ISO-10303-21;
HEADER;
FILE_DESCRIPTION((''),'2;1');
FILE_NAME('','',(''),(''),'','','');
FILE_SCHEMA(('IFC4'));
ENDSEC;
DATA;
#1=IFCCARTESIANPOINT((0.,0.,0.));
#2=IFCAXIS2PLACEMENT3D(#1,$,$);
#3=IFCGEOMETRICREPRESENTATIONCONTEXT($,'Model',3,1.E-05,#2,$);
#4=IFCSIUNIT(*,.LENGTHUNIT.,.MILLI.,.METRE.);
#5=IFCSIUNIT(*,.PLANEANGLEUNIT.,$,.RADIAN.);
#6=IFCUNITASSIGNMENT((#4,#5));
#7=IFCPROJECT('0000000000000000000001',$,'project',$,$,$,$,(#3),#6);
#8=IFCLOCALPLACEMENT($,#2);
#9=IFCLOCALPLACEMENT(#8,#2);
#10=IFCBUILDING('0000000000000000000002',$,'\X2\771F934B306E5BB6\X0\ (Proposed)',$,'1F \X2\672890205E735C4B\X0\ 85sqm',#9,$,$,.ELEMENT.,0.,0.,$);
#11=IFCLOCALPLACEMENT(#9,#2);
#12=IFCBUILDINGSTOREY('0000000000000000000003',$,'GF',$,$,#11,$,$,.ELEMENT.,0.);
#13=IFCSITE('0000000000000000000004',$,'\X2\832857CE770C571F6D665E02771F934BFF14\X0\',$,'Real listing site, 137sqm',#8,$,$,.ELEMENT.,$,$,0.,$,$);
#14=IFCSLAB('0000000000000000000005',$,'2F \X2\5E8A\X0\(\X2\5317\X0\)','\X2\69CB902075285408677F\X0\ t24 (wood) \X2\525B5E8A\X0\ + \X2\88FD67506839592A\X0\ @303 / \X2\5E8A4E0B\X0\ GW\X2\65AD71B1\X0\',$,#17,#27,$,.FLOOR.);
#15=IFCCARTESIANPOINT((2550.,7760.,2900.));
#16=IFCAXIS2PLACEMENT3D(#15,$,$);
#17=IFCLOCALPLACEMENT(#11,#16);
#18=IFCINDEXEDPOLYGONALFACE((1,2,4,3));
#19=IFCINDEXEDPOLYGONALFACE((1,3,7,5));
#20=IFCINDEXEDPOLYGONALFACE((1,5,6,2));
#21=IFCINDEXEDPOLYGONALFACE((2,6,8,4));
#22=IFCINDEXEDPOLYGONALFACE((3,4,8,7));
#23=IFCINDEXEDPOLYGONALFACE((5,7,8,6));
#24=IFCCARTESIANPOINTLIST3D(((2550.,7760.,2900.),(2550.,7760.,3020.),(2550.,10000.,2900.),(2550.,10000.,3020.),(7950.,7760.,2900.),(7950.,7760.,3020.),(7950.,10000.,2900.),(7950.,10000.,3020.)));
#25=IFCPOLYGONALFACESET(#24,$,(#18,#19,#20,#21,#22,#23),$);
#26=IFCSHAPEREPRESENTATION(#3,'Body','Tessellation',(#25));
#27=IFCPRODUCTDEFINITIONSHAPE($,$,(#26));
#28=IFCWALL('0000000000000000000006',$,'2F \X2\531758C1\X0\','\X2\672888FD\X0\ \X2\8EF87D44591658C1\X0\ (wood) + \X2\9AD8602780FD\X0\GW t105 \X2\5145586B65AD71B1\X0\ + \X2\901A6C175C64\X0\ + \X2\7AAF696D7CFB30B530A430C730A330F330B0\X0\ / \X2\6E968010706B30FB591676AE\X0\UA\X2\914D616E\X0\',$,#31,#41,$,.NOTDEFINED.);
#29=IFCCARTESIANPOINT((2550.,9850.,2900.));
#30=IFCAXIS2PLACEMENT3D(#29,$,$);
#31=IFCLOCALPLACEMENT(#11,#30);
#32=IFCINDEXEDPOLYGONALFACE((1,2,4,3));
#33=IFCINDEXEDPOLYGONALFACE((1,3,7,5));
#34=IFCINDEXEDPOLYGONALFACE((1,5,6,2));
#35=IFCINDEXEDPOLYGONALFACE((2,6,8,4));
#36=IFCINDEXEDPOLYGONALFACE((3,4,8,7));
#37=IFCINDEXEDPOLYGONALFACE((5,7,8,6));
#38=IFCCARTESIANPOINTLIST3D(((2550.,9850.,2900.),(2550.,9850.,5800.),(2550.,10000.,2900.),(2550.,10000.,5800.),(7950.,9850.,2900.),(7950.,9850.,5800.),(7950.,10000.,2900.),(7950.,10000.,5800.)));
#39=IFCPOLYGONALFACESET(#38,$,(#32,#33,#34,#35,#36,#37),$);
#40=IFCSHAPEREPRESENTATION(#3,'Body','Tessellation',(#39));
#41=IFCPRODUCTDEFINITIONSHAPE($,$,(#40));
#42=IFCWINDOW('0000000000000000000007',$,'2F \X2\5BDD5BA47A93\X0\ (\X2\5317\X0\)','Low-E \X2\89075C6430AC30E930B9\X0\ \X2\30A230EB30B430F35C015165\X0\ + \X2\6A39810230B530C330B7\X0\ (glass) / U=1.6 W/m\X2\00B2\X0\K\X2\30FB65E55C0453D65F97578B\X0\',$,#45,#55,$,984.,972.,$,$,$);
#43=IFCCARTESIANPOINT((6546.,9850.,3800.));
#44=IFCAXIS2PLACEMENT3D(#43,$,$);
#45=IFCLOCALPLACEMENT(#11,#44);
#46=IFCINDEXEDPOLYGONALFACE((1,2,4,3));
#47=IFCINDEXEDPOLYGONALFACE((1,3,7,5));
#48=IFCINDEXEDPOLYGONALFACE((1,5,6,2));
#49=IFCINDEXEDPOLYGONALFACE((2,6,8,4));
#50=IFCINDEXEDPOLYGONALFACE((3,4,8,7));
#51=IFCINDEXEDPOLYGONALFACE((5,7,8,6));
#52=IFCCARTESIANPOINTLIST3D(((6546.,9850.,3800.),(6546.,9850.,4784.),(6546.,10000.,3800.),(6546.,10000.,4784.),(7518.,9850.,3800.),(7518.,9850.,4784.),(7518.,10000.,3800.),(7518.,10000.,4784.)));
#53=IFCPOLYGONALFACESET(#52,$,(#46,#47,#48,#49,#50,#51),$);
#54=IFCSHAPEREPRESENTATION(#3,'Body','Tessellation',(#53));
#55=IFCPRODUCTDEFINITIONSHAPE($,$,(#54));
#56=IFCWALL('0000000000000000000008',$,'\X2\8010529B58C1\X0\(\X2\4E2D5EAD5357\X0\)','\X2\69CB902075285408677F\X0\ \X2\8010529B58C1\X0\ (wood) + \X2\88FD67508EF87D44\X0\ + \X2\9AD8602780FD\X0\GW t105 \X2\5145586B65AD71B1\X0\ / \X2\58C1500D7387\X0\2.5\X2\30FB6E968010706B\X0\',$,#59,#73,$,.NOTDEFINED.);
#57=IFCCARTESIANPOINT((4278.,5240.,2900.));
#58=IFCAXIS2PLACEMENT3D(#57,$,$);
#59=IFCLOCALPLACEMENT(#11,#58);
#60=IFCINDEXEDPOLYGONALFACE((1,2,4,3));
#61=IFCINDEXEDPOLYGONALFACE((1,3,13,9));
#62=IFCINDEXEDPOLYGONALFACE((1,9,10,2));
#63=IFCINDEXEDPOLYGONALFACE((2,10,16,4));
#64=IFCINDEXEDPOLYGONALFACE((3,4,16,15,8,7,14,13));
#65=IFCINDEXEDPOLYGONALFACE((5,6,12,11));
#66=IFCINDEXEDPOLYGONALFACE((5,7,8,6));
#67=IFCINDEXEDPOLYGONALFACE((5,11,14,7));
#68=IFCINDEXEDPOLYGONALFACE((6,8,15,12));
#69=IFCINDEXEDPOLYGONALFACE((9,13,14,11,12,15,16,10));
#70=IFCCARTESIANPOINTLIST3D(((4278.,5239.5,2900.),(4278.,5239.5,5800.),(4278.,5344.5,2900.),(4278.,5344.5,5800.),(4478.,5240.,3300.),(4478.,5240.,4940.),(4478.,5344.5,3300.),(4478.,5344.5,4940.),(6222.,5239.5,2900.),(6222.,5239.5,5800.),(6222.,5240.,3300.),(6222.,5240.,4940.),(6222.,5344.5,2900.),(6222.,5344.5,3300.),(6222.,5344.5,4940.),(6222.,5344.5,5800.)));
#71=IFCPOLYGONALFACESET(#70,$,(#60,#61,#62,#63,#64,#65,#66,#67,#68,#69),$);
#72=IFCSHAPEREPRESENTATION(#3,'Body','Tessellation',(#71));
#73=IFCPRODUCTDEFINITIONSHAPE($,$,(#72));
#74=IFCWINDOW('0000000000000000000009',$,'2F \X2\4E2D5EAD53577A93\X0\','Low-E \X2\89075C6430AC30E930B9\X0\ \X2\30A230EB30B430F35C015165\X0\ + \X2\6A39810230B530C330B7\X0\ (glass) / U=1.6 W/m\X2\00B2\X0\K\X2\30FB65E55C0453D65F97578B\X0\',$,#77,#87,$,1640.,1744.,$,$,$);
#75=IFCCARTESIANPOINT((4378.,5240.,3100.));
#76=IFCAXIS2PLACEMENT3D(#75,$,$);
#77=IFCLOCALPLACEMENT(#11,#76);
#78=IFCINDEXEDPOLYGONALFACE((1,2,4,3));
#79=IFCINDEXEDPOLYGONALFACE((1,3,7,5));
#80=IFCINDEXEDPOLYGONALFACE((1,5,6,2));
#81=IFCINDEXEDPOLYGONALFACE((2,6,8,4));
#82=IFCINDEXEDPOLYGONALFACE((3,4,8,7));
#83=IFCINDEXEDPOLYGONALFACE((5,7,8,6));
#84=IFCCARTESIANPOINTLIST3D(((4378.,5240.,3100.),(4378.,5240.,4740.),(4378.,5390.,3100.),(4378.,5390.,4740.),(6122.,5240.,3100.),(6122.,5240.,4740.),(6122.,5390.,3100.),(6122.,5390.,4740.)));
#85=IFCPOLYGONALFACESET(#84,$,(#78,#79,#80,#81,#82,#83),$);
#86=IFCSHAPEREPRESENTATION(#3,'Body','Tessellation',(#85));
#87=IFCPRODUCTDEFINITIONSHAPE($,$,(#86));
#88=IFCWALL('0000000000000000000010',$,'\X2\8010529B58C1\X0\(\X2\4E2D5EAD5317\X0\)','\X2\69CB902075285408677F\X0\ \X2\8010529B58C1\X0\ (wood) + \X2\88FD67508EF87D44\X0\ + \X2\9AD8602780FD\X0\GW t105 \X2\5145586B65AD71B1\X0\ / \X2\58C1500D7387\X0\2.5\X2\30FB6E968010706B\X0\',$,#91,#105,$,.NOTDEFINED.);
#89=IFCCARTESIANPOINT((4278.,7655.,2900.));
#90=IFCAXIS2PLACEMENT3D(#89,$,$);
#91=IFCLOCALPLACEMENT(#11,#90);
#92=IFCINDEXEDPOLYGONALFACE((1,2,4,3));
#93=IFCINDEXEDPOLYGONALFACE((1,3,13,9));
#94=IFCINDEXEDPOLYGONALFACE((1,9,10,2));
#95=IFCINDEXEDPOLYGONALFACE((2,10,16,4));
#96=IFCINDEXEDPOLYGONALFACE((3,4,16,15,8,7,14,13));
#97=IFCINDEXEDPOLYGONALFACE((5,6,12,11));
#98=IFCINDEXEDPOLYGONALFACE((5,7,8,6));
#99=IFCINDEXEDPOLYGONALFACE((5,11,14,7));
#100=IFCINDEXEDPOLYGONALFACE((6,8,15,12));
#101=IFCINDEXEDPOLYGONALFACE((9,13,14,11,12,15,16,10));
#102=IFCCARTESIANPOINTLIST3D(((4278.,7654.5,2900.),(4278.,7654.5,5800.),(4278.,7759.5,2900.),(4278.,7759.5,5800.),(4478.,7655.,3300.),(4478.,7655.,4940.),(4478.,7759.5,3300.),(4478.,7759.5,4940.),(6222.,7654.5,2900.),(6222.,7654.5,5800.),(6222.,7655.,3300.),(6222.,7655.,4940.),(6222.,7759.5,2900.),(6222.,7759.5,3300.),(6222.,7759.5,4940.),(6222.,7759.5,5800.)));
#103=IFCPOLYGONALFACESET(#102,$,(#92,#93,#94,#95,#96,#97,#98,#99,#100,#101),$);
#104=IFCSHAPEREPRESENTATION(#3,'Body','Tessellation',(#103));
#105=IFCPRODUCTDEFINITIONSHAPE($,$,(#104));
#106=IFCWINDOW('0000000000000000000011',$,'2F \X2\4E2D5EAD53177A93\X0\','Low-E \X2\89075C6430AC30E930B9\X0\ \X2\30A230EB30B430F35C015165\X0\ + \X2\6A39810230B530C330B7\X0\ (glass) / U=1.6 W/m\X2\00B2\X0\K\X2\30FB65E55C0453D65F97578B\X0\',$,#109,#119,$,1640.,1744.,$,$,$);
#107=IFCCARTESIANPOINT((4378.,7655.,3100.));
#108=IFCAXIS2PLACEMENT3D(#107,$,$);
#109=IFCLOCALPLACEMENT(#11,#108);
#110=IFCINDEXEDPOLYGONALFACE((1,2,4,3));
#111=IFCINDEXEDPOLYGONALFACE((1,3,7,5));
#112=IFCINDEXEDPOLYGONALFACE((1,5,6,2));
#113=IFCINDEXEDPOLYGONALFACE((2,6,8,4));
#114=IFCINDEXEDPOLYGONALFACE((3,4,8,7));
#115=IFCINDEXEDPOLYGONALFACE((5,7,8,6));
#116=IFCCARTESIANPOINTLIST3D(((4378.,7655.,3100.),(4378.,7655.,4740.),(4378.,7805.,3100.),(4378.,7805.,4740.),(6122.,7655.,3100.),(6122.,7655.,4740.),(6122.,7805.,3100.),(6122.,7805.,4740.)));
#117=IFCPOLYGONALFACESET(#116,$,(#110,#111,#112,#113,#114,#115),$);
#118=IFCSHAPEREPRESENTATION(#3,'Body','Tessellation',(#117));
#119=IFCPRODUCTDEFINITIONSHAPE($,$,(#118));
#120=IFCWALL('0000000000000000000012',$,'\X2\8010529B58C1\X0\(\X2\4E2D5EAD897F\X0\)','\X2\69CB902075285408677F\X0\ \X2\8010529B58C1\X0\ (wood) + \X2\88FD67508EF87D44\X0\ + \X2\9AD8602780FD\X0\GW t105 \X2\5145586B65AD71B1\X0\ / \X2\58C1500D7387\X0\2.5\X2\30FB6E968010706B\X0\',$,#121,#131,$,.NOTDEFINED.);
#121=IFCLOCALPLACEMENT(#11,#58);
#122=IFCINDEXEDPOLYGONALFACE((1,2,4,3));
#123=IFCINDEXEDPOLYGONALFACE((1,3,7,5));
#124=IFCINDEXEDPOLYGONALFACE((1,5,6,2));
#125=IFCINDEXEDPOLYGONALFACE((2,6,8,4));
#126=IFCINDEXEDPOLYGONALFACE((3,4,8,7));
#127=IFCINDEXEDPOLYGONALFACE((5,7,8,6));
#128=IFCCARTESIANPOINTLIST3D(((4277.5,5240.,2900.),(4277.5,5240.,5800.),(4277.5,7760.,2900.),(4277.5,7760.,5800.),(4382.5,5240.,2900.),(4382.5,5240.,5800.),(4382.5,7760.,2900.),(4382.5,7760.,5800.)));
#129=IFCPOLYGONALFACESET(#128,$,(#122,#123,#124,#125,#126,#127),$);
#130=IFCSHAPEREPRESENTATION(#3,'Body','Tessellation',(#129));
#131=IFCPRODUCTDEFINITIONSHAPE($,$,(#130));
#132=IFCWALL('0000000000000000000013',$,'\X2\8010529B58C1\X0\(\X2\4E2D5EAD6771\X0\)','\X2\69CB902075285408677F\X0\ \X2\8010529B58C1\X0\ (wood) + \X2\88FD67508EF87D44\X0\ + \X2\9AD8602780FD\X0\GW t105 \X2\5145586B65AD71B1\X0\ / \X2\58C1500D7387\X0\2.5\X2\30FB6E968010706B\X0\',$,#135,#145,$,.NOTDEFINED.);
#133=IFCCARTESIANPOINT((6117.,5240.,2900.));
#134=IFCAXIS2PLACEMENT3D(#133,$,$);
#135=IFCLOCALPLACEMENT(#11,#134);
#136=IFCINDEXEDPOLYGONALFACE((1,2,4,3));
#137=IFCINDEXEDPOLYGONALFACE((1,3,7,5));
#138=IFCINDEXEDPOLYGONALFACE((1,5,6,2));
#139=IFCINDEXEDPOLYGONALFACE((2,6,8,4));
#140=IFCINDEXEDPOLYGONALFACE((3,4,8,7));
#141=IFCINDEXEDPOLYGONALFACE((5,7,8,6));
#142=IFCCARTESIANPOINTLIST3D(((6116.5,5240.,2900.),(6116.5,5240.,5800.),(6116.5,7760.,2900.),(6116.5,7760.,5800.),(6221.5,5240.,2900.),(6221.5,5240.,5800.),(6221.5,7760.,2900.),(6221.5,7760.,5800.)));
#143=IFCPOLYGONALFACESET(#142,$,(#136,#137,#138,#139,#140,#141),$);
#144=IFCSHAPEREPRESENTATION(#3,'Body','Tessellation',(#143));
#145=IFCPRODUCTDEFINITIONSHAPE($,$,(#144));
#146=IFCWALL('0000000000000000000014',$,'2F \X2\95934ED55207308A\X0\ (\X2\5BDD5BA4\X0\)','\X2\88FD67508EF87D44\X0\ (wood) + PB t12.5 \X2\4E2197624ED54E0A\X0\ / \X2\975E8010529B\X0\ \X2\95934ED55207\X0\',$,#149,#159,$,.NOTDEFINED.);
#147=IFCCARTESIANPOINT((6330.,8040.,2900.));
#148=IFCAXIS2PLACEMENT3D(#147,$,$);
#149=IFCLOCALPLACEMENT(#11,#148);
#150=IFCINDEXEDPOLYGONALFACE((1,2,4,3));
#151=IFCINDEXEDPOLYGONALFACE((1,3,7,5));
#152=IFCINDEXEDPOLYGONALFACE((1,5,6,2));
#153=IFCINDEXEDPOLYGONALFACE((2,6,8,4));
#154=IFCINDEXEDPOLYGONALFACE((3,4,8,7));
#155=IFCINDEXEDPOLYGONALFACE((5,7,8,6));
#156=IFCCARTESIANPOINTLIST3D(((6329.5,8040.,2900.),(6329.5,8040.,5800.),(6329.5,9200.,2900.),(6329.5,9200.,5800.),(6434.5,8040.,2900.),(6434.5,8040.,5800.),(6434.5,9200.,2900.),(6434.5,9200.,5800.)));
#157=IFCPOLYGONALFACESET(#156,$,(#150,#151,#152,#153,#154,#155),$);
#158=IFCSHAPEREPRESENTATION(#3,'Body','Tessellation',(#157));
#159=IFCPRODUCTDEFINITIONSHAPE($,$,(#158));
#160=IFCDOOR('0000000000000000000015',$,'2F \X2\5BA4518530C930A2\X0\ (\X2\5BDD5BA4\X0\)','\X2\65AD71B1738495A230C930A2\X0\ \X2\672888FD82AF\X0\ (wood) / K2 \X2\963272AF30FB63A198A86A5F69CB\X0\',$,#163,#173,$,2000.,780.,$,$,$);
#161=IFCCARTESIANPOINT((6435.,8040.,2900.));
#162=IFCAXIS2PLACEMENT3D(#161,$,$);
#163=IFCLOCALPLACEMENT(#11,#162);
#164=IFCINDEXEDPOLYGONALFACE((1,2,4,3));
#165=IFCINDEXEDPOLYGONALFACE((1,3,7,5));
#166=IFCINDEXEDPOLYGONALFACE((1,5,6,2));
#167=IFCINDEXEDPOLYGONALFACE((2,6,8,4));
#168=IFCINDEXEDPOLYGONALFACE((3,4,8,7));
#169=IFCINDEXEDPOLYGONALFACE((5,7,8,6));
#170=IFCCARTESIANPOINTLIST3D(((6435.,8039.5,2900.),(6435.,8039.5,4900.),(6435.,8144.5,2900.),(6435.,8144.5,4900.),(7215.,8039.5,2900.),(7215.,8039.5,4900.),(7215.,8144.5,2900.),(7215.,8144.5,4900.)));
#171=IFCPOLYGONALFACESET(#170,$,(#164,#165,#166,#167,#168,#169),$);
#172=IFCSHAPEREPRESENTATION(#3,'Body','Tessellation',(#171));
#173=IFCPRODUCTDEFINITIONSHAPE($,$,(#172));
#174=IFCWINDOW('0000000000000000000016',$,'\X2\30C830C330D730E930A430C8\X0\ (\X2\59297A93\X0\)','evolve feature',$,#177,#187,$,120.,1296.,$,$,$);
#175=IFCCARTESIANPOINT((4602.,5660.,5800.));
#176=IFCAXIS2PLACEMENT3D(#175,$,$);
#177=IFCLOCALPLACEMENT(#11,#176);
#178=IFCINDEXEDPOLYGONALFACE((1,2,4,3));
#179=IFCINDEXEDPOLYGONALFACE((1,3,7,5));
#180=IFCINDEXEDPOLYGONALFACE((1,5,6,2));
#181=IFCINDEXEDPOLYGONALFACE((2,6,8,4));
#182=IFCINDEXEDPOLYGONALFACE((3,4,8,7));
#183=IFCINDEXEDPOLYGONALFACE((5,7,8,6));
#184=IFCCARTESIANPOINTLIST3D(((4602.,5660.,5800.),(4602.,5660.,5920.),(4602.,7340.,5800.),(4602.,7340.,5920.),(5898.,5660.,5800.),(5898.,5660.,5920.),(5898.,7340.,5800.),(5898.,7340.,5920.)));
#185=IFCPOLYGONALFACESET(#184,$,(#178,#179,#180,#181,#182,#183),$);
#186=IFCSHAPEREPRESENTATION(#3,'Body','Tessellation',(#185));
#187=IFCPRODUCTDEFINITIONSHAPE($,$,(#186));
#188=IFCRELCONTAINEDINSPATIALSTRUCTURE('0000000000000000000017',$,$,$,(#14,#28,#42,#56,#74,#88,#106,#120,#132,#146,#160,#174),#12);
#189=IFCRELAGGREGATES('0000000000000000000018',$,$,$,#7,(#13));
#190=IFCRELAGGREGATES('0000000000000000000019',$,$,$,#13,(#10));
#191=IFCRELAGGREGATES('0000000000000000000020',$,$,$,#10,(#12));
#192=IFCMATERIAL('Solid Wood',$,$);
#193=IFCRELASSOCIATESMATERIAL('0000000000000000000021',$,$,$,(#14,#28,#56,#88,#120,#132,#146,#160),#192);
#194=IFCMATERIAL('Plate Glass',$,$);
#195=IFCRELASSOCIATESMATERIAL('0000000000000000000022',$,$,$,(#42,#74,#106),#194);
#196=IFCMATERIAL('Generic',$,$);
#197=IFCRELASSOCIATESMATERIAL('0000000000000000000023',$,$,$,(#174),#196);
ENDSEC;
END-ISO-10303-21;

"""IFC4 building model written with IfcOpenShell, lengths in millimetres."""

from ifc_helpers import new_model, si_unit, frame, frame_2d, origin, place, context, project, spatial, rectangle, extrude, material, element, fill, save


model = new_model("IFC4")

# Units and contexts
model_context = context("Model", 3, precision=1e-05, world=origin())
ifc_project = project(units=[si_unit("LENGTHUNIT", "METRE", prefix="MILLI"), si_unit("PLANEANGLEUNIT", "RADIAN")], contexts=[model_context])

# Site, building, storey
site_placement = place(None, origin())
site = spatial("IfcSite", under=ifc_project, at=site_placement, Name="茨城県土浦市真鍋４", ObjectType="Real listing site, 137sqm", CompositionType="ELEMENT", RefElevation=0.0)
building_placement = place(site_placement, origin())
building = spatial("IfcBuilding", under=site, at=building_placement, Name="真鍋の家 (Proposed)", ObjectType="1F 木造平屋 85sqm", CompositionType="ELEMENT", ElevationOfRefHeight=0.0, ElevationOfTerrain=0.0)
storey_placement = place(building_placement, origin())
storey = spatial("IfcBuildingStorey", under=building, at=storey_placement, Name="GF", CompositionType="ELEMENT", Elevation=0.0)

# Slab
ifc_material_1 = material(Name="Solid Wood")
slab_placement = place(storey_placement, frame((2550.0, 7760.0, 2900.0)))
element("IfcSlab", 1, at=slab_placement, inside=storey, material=ifc_material_1, Name="2F 床(北)", Description="構造用合板 t24 (wood) 剛床 + 製材根太 @303 / 床下 GW断熱", PredefinedType="FLOOR", context=model_context, shape_type="SweptSolid", body=[
    extrude(rectangle(XDim=5400.0, YDim=2240.0, at=frame_2d((2700.0, 1120.0))), frame((2550.0, 7760.0, 2900.0)), (0.0, 0.0, 1.0), 120.0),
])

# Walls, openings, windows
wall_1_placement = place(storey_placement, frame((2550.0, 9850.0, 2900.0)))
wall_1 = element("IfcWall", 2, at=wall_1_placement, inside=storey, material=ifc_material_1, Name="2F 北壁", Description="木製 軸組外壁 (wood) + 高性能GW t105 充填断熱 + 通気層 + 窯業系サイディング / 準耐火・外皮UA配慮", PredefinedType="NOTDEFINED", context=model_context, shape_type="SweptSolid", body=[
    extrude(rectangle(XDim=5400.0, YDim=150.0, at=frame_2d((2700.0, 75.0))), frame((2550.0, 9850.0, 2900.0)), (0.0, 0.0, 1.0), 2900.0),
])
opening_1_placement = place(storey_placement, frame((6546.0, 9850.0, 3800.0)))
opening_1 = element("IfcOpeningElement", 3, at=opening_1_placement, cuts=wall_1, PredefinedType="NOTDEFINED", context=model_context, shape_type="SweptSolid", body=[
    extrude(rectangle(XDim=972.0, YDim=150.0, at=frame_2d((486.0, 75.0))), frame((6546.0, 9850.0, 3800.0)), (0.0, 0.0, 1.0), 984.0),
])
ifc_material_2 = material(Name="Plate Glass")
window_1_placement = place(storey_placement, frame((6546.0, 9850.0, 3800.0)))
window_1 = element("IfcWindow", 4, at=window_1_placement, inside=storey, material=ifc_material_2, Name="2F 寝室窓 (北)", Description="Low-E 複層ガラス アルゴン封入 + 樹脂サッシ (glass) / U=1.6 W/m²K・日射取得型", OverallHeight=984.0, OverallWidth=972.0, context=model_context, shape_type="SweptSolid", body=[
    extrude(rectangle(XDim=972.0, YDim=150.0, at=frame_2d((486.0, 75.0))), frame((6546.0, 9850.0, 3800.0)), (0.0, 0.0, 1.0), 984.0),
])
fill(opening_1, window_1)
wall_2_placement = place(storey_placement, frame((4278.0, 5240.0, 2900.0)))
wall_2 = element("IfcWall", 5, at=wall_2_placement, inside=storey, material=ifc_material_1, Name="耐力壁(中庭南)", Description="構造用合板 耐力壁 (wood) + 製材軸組 + 高性能GW t105 充填断熱 / 壁倍率2.5・準耐火", PredefinedType="NOTDEFINED", context=model_context, shape_type="SweptSolid", body=[
    extrude(rectangle(XDim=1944.0, YDim=105.0, at=frame_2d((972.0, 52.0))), frame((4278.0, 5240.0, 2900.0)), (0.0, 0.0, 1.0), 2900.0),
])
opening_2_placement = place(storey_placement, frame((4378.0, 5240.0, 3100.0)))
opening_2 = element("IfcOpeningElement", 6, at=opening_2_placement, cuts=wall_2, PredefinedType="NOTDEFINED", context=model_context, shape_type="SweptSolid", body=[
    extrude(rectangle(XDim=1744.0, YDim=150.0, at=frame_2d((872.0, 75.0))), frame((4378.0, 5240.0, 3100.0)), (0.0, 0.0, 1.0), 1640.0),
])
window_2_placement = place(storey_placement, frame((4378.0, 5240.0, 3100.0)))
window_2 = element("IfcWindow", 7, at=window_2_placement, inside=storey, material=ifc_material_2, Name="2F 中庭南窓", Description="Low-E 複層ガラス アルゴン封入 + 樹脂サッシ (glass) / U=1.6 W/m²K・日射取得型", OverallHeight=1640.0, OverallWidth=1744.0, context=model_context, shape_type="SweptSolid", body=[
    extrude(rectangle(XDim=1744.0, YDim=150.0, at=frame_2d((872.0, 75.0))), frame((4378.0, 5240.0, 3100.0)), (0.0, 0.0, 1.0), 1640.0),
])
fill(opening_2, window_2)
wall_3_placement = place(storey_placement, frame((4278.0, 7655.0, 2900.0)))
wall_3 = element("IfcWall", 8, at=wall_3_placement, inside=storey, material=ifc_material_1, Name="耐力壁(中庭北)", Description="構造用合板 耐力壁 (wood) + 製材軸組 + 高性能GW t105 充填断熱 / 壁倍率2.5・準耐火", PredefinedType="NOTDEFINED", context=model_context, shape_type="SweptSolid", body=[
    extrude(rectangle(XDim=1944.0, YDim=105.0, at=frame_2d((972.0, 52.0))), frame((4278.0, 7655.0, 2900.0)), (0.0, 0.0, 1.0), 2900.0),
])
opening_3_placement = place(storey_placement, frame((4378.0, 7655.0, 3100.0)))
opening_3 = element("IfcOpeningElement", 9, at=opening_3_placement, cuts=wall_3, PredefinedType="NOTDEFINED", context=model_context, shape_type="SweptSolid", body=[
    extrude(rectangle(XDim=1744.0, YDim=150.0, at=frame_2d((872.0, 75.0))), frame((4378.0, 7655.0, 3100.0)), (0.0, 0.0, 1.0), 1640.0),
])
window_3_placement = place(storey_placement, frame((4378.0, 7655.0, 3100.0)))
window_3 = element("IfcWindow", 10, at=window_3_placement, inside=storey, material=ifc_material_2, Name="2F 中庭北窓", Description="Low-E 複層ガラス アルゴン封入 + 樹脂サッシ (glass) / U=1.6 W/m²K・日射取得型", OverallHeight=1640.0, OverallWidth=1744.0, context=model_context, shape_type="SweptSolid", body=[
    extrude(rectangle(XDim=1744.0, YDim=150.0, at=frame_2d((872.0, 75.0))), frame((4378.0, 7655.0, 3100.0)), (0.0, 0.0, 1.0), 1640.0),
])
fill(opening_3, window_3)

# Walls
wall_4_placement = place(storey_placement, frame((4278.0, 5240.0, 2900.0)))
element("IfcWall", 11, at=wall_4_placement, inside=storey, material=ifc_material_1, Name="耐力壁(中庭西)", Description="構造用合板 耐力壁 (wood) + 製材軸組 + 高性能GW t105 充填断熱 / 壁倍率2.5・準耐火", PredefinedType="NOTDEFINED", context=model_context, shape_type="SweptSolid", body=[
    extrude(rectangle(XDim=105.0, YDim=2520.0, at=frame_2d((52.0, 1260.0))), frame((4278.0, 5240.0, 2900.0)), (0.0, 0.0, 1.0), 2900.0),
])
wall_5_placement = place(storey_placement, frame((6117.0, 5240.0, 2900.0)))
element("IfcWall", 12, at=wall_5_placement, inside=storey, material=ifc_material_1, Name="耐力壁(中庭東)", Description="構造用合板 耐力壁 (wood) + 製材軸組 + 高性能GW t105 充填断熱 / 壁倍率2.5・準耐火", PredefinedType="NOTDEFINED", context=model_context, shape_type="SweptSolid", body=[
    extrude(rectangle(XDim=105.0, YDim=2520.0, at=frame_2d((52.0, 1260.0))), frame((6117.0, 5240.0, 2900.0)), (0.0, 0.0, 1.0), 2900.0),
])
wall_6_placement = place(storey_placement, frame((6330.0, 8040.0, 2900.0)))
element("IfcWall", 13, at=wall_6_placement, inside=storey, material=ifc_material_1, Name="2F 間仕切り (寝室)", Description="製材軸組 (wood) + PB t12.5 両面仕上 / 非耐力 間仕切", PredefinedType="NOTDEFINED", context=model_context, shape_type="SweptSolid", body=[
    extrude(rectangle(XDim=105.0, YDim=1160.0, at=frame_2d((52.0, 580.0))), frame((6330.0, 8040.0, 2900.0)), (0.0, 0.0, 1.0), 2900.0),
])

# Door
door_placement = place(storey_placement, frame((6435.0, 8040.0, 2900.0)))
element("IfcDoor", 14, at=door_placement, inside=storey, material=ifc_material_1, Name="2F 室内ドア (寝室)", Description="断熱玄関ドア 木製芯 (wood) / K2 防犯・採風機構", OverallHeight=2000.0, OverallWidth=780.0, context=model_context, shape_type="SweptSolid", body=[
    extrude(rectangle(XDim=780.0, YDim=105.0, at=frame_2d((390.0, 52.0))), frame((6435.0, 8040.0, 2900.0)), (0.0, 0.0, 1.0), 2000.0),
])

# Window
ifc_material_3 = material(Name="Generic")
window_4_placement = place(storey_placement, frame((4602.0, 5660.0, 5800.0)))
element("IfcWindow", 15, at=window_4_placement, inside=storey, material=ifc_material_3, Name="トップライト (天窓)", Description="evolve feature", OverallHeight=120.0, OverallWidth=1296.0, context=model_context, shape_type="SweptSolid", body=[
    extrude(rectangle(XDim=1296.0, YDim=1680.0, at=frame_2d((648.0, 840.0))), frame((4602.0, 5660.0, 5800.0)), (0.0, 0.0, 1.0), 120.0),
])

save(model, "model.ifc")
